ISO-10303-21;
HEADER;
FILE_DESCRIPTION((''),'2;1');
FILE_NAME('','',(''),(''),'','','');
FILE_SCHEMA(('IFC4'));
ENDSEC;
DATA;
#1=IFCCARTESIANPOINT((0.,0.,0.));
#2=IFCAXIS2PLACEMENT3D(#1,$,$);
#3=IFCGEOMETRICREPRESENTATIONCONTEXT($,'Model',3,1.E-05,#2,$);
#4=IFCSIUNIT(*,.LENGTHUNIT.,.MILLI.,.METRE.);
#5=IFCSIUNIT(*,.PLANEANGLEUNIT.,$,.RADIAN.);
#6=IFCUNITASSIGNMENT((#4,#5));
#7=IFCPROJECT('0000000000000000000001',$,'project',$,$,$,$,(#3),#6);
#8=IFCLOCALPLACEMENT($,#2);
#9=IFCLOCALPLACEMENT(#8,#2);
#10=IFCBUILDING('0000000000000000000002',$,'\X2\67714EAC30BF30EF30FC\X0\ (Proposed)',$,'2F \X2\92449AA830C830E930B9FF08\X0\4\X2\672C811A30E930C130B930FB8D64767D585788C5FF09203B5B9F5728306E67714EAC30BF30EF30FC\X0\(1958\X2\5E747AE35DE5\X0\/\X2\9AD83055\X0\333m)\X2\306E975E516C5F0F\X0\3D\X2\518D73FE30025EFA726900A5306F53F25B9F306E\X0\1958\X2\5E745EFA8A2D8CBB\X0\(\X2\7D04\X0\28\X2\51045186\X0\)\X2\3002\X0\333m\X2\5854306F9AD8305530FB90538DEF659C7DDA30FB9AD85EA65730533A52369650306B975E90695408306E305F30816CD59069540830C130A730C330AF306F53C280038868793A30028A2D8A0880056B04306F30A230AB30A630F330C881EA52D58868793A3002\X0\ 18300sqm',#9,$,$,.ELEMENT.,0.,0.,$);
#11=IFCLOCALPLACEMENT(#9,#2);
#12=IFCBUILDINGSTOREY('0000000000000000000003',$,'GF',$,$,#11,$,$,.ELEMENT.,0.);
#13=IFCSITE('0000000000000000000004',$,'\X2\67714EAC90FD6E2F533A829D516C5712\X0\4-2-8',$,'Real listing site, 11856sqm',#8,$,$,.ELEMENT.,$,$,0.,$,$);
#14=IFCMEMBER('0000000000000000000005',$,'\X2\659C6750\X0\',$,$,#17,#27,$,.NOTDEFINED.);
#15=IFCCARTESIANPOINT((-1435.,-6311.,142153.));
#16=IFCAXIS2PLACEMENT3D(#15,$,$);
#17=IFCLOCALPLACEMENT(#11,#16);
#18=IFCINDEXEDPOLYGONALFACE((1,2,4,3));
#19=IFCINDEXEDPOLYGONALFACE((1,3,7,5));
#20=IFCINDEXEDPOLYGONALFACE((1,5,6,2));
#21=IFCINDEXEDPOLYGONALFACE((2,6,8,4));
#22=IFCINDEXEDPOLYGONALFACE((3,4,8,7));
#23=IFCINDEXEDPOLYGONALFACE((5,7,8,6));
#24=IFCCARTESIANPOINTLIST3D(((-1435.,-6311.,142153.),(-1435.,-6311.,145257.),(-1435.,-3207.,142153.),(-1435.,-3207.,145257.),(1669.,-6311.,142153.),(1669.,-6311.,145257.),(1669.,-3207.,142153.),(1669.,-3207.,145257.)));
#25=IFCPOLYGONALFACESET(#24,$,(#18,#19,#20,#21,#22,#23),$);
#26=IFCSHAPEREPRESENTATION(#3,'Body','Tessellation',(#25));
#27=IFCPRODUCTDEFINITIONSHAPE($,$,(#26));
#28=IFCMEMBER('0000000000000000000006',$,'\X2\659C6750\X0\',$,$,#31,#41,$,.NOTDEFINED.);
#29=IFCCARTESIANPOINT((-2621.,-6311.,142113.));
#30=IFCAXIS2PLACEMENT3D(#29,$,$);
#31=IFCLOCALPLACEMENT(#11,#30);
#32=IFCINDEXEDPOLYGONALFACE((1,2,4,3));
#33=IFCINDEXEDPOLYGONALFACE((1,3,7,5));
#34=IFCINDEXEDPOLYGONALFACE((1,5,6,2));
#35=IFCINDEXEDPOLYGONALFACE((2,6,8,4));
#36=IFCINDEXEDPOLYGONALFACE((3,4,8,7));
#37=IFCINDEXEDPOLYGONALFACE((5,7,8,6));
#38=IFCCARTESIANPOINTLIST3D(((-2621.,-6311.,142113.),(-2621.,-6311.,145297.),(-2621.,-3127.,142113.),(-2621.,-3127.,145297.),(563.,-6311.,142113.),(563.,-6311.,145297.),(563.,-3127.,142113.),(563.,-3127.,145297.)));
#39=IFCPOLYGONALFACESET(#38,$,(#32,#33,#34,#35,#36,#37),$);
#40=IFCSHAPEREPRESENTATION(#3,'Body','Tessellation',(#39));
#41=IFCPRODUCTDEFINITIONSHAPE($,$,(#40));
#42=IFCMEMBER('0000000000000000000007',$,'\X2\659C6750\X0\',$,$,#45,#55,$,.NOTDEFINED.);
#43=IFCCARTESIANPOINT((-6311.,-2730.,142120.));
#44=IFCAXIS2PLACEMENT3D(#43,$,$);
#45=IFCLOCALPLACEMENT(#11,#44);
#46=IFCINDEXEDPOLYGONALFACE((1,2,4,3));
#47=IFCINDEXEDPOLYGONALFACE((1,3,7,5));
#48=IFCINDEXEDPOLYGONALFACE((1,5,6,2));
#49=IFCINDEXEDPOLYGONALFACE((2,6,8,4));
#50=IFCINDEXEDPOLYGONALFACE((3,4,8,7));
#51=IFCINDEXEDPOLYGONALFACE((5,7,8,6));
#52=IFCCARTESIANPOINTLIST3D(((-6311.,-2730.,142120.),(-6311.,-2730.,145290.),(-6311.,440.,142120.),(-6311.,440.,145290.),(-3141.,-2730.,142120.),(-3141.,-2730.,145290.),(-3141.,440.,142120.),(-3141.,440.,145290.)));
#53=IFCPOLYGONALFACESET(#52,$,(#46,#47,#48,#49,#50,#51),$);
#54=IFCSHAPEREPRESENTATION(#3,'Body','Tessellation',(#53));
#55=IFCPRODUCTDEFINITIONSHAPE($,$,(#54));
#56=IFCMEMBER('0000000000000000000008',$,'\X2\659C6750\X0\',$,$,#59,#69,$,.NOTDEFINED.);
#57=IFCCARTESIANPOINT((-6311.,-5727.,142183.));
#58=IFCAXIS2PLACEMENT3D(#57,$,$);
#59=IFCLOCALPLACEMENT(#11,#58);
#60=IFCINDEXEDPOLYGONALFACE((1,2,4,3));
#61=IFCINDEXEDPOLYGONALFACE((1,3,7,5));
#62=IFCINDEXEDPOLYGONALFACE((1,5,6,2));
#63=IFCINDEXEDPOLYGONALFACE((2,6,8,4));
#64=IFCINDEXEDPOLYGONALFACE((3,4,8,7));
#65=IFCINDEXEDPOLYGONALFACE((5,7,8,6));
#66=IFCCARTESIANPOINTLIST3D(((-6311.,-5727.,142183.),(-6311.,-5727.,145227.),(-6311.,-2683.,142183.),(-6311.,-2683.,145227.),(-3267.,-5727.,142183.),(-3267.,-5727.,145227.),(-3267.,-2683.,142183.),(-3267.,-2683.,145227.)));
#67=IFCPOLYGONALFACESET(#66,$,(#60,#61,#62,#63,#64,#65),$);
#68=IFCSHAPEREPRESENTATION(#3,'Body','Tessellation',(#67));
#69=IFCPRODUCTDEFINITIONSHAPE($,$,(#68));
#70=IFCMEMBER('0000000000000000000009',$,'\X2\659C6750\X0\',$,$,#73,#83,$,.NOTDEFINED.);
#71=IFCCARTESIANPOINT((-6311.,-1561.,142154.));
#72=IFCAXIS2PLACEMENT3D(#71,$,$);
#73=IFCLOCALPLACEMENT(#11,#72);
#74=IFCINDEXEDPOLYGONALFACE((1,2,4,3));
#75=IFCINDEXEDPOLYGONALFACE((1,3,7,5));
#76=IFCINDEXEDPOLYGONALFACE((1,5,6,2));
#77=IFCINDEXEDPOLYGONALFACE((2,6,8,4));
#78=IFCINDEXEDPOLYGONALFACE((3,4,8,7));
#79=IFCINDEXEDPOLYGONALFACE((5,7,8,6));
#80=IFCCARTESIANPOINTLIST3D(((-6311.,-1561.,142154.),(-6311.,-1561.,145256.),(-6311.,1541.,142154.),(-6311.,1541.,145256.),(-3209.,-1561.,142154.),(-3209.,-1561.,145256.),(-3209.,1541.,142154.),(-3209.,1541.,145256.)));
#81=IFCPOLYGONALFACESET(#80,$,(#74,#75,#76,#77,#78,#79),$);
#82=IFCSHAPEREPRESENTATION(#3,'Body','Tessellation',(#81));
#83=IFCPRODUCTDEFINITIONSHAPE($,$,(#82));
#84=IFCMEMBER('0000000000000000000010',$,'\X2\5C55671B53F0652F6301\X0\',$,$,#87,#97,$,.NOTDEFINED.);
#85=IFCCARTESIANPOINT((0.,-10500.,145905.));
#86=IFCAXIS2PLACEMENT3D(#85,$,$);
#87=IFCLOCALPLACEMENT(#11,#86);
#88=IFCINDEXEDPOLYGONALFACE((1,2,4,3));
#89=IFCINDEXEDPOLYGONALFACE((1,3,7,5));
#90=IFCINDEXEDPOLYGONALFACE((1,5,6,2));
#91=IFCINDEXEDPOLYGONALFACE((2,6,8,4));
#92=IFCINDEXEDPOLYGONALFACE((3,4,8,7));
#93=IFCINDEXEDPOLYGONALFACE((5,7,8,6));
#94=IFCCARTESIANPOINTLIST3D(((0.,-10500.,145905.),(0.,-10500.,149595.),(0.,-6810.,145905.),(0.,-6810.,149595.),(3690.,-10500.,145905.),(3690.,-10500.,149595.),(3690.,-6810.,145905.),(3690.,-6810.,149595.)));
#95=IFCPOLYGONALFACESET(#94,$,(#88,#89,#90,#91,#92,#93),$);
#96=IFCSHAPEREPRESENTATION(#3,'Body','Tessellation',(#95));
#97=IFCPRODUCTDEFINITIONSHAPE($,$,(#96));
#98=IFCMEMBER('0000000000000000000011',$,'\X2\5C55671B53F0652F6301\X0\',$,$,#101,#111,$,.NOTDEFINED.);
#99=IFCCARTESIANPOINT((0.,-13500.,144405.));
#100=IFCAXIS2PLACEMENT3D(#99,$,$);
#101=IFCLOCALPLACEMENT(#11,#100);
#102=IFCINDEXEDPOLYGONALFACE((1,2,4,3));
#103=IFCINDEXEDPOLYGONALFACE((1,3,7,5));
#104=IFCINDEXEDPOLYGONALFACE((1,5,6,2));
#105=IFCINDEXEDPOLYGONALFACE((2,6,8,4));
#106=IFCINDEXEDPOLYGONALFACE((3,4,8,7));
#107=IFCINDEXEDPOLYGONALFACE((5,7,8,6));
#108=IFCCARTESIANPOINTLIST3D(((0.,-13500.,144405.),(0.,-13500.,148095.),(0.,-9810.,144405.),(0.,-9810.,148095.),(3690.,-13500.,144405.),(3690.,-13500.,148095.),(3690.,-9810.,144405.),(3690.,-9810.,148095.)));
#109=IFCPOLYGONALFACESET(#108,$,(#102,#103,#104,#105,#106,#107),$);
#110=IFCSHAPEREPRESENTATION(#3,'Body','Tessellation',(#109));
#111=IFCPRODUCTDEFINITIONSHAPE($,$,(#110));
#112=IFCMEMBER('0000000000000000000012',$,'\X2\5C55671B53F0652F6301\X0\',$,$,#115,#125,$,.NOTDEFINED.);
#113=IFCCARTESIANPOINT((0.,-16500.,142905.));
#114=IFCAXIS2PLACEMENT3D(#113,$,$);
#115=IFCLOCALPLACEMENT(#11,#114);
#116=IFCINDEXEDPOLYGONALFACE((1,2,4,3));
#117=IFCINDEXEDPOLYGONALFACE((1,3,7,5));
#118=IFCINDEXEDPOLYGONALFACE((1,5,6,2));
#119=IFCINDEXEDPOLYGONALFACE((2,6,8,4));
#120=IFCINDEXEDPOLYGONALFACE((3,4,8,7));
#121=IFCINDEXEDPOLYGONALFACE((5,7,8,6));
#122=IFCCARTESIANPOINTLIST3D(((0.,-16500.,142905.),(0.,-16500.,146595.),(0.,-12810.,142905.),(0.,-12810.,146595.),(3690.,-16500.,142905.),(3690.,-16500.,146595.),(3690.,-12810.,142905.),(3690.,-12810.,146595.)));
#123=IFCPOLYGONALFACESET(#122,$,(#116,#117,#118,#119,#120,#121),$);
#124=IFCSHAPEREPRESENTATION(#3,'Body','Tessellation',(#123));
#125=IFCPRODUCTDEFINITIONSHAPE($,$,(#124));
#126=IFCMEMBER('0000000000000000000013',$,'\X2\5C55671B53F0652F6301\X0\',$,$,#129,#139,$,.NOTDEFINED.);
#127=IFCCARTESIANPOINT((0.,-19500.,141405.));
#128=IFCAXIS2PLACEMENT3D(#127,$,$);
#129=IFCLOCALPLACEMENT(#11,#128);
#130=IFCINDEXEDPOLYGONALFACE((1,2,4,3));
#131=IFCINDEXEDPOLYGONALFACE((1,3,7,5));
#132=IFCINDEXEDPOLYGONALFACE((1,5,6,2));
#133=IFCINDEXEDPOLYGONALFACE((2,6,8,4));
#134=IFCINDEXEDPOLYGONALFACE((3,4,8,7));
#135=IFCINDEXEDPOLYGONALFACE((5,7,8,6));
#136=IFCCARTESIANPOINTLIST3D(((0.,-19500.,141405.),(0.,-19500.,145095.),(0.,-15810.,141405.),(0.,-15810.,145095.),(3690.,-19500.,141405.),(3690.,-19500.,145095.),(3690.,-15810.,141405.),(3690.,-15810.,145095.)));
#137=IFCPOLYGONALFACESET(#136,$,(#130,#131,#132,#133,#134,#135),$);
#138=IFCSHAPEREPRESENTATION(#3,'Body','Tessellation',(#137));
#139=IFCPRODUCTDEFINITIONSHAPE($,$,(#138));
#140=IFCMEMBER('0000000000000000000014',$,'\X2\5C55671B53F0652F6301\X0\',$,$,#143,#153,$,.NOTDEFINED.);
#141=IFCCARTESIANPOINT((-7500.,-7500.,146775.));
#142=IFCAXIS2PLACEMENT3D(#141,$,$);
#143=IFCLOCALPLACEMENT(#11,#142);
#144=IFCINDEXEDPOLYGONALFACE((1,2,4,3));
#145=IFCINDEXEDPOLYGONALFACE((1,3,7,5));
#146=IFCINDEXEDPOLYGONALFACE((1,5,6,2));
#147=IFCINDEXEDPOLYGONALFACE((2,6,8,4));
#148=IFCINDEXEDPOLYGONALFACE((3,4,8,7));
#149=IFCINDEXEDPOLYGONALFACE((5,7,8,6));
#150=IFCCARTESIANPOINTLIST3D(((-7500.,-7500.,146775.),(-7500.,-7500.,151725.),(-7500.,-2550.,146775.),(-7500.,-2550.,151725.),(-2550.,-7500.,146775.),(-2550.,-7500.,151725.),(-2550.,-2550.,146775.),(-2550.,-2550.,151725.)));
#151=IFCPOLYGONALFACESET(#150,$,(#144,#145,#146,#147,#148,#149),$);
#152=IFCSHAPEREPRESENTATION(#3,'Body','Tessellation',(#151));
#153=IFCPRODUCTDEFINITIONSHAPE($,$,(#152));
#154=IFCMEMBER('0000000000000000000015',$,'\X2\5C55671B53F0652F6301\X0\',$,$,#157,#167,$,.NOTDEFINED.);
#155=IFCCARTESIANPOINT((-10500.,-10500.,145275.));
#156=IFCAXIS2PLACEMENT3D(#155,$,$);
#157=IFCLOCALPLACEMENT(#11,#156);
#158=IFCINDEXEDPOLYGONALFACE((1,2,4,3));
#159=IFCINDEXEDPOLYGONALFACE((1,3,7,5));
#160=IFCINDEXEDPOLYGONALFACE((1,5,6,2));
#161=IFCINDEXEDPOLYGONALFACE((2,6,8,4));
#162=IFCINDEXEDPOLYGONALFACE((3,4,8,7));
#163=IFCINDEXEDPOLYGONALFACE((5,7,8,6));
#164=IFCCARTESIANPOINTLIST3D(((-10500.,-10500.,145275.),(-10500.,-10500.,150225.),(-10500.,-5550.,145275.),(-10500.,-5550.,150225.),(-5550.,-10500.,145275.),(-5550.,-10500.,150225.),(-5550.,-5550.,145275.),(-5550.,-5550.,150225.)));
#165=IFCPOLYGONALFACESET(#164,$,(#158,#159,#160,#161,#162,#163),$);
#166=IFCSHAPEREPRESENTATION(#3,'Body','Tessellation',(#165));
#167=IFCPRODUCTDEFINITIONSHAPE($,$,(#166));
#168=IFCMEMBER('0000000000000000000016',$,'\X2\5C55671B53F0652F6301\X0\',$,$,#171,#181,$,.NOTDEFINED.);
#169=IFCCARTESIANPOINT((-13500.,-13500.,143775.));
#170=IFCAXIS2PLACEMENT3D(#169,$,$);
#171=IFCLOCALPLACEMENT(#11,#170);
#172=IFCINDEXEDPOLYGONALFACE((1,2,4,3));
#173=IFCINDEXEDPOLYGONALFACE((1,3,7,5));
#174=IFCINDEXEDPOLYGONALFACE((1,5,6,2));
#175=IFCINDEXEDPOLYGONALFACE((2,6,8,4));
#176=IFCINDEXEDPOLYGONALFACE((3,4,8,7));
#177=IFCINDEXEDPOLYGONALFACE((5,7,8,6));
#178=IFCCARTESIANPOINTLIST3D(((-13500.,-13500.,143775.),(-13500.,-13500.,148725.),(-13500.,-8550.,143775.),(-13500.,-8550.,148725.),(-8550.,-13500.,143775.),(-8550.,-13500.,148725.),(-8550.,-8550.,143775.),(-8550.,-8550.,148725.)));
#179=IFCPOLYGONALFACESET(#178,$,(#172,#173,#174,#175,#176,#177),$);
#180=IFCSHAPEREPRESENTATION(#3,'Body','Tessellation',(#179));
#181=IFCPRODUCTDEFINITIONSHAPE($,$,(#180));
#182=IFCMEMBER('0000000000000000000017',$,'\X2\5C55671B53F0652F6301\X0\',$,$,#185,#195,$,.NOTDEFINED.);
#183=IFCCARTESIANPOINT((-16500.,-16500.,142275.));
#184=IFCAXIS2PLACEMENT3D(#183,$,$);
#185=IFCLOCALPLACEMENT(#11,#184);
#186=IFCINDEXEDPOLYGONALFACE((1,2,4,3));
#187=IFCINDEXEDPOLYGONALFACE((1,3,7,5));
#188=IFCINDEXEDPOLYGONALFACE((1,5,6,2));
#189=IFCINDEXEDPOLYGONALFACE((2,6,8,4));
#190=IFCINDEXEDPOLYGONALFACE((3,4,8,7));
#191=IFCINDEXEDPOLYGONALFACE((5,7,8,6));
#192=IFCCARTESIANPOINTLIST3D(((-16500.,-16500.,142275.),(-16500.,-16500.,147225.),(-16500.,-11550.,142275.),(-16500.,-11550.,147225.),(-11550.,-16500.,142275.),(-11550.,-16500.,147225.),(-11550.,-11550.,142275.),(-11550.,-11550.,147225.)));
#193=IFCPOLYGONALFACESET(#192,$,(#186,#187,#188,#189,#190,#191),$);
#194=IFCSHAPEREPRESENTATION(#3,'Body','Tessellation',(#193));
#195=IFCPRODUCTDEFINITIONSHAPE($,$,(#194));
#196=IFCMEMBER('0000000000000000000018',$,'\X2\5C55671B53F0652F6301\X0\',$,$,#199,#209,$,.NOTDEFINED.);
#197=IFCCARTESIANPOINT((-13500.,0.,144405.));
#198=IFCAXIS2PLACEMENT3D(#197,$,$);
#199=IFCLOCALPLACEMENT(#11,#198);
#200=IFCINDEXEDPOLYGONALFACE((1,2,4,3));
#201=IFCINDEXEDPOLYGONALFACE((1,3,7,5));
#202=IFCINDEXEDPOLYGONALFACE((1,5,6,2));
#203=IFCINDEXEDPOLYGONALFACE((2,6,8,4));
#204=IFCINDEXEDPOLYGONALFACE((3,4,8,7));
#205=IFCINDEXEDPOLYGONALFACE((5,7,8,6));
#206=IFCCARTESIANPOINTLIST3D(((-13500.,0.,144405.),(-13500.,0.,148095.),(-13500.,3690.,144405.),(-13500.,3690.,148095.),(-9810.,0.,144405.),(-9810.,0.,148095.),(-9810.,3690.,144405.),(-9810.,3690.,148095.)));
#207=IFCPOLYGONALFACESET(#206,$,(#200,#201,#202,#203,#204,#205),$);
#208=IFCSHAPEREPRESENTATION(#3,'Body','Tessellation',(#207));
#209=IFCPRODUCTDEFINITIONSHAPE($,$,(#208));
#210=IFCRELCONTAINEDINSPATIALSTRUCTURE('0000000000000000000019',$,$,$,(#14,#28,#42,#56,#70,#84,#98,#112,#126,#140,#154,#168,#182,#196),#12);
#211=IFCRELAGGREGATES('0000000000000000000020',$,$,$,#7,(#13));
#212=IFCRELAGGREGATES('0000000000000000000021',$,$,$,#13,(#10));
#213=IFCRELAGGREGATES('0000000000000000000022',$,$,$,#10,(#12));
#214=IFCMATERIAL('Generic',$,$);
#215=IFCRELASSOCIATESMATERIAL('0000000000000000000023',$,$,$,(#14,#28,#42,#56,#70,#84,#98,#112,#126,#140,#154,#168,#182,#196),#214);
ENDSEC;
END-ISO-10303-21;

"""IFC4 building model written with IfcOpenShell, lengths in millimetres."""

from ifc_helpers import new_model, si_unit, frame, frame_2d, origin, place, context, project, spatial, rectangle, extrude, material, element, save


model = new_model("IFC4")

# Units and contexts
model_context = context("Model", 3, precision=1e-05, world=origin())
ifc_project = project(units=[si_unit("LENGTHUNIT", "METRE", prefix="MILLI"), si_unit("PLANEANGLEUNIT", "RADIAN")], contexts=[model_context])

# Site, building, storey
site_placement = place(None, origin())
site = spatial("IfcSite", under=ifc_project, at=site_placement, Name="東京都港区芝公園4-2-8", ObjectType="Real listing site, 11856sqm", CompositionType="ELEMENT", RefElevation=0.0)
building_placement = place(site_placement, origin())
building = spatial("IfcBuilding", under=site, at=building_placement, Name="東京タワー (Proposed)", ObjectType="2F 鉄骨トラス（4本脚ラチス・赤白塗装）※実在の東京タワー(1958年竣工/高さ333m)の非公式3D再現。建物¥は史実の1958年建設費(約28億円)。333m塔は高さ・道路斜線・高度地区制限に非適合のため法適合チェックは参考表示。設計者欄はアカウント自動表示。 18300sqm", CompositionType="ELEMENT", ElevationOfRefHeight=0.0, ElevationOfTerrain=0.0)
storey_placement = place(building_placement, origin())
storey = spatial("IfcBuildingStorey", under=building, at=storey_placement, Name="GF", CompositionType="ELEMENT", Elevation=0.0)

# Shared definitions
ifc_material = material(Name="Generic")

# Members
member_1_placement = place(storey_placement, frame((-1435.0, -6311.0, 142153.0)))
element("IfcMember", 1, at=member_1_placement, inside=storey, material=ifc_material, Name="斜材", PredefinedType="NOTDEFINED", context=model_context, shape_type="SweptSolid", body=[
    extrude(rectangle(XDim=3104.0, YDim=3104.0, at=frame_2d((1552.0, 1552.0))), frame((-1435.0, -6311.0, 142153.0)), (0.0, 0.0, 1.0), 3104.0),
])
member_2_placement = place(storey_placement, frame((-2621.0, -6311.0, 142113.0)))
element("IfcMember", 2, at=member_2_placement, inside=storey, material=ifc_material, Name="斜材", PredefinedType="NOTDEFINED", context=model_context, shape_type="SweptSolid", body=[
    extrude(rectangle(XDim=3184.0, YDim=3184.0, at=frame_2d((1592.0, 1592.0))), frame((-2621.0, -6311.0, 142113.0)), (0.0, 0.0, 1.0), 3184.0),
])
member_3_placement = place(storey_placement, frame((-6311.0, -2730.0, 142120.0)))
element("IfcMember", 3, at=member_3_placement, inside=storey, material=ifc_material, Name="斜材", PredefinedType="NOTDEFINED", context=model_context, shape_type="SweptSolid", body=[
    extrude(rectangle(XDim=3170.0, YDim=3170.0, at=frame_2d((1585.0, 1585.0))), frame((-6311.0, -2730.0, 142120.0)), (0.0, 0.0, 1.0), 3170.0),
])
member_4_placement = place(storey_placement, frame((-6311.0, -5727.0, 142183.0)))
element("IfcMember", 4, at=member_4_placement, inside=storey, material=ifc_material, Name="斜材", PredefinedType="NOTDEFINED", context=model_context, shape_type="SweptSolid", body=[
    extrude(rectangle(XDim=3044.0, YDim=3044.0, at=frame_2d((1522.0, 1522.0))), frame((-6311.0, -5727.0, 142183.0)), (0.0, 0.0, 1.0), 3044.0),
])
member_5_placement = place(storey_placement, frame((-6311.0, -1561.0, 142154.0)))
element("IfcMember", 5, at=member_5_placement, inside=storey, material=ifc_material, Name="斜材", PredefinedType="NOTDEFINED", context=model_context, shape_type="SweptSolid", body=[
    extrude(rectangle(XDim=3102.0, YDim=3102.0, at=frame_2d((1551.0, 1551.0))), frame((-6311.0, -1561.0, 142154.0)), (0.0, 0.0, 1.0), 3102.0),
])
member_6_placement = place(storey_placement, frame((0.0, -10500.0, 145905.0)))
element("IfcMember", 6, at=member_6_placement, inside=storey, material=ifc_material, Name="展望台支持", PredefinedType="NOTDEFINED", context=model_context, shape_type="SweptSolid", body=[
    extrude(rectangle(XDim=3690.0, YDim=3690.0, at=frame_2d((1845.0, 1845.0))), frame((0.0, -10500.0, 145905.0)), (0.0, 0.0, 1.0), 3690.0),
])
member_7_placement = place(storey_placement, frame((0.0, -13500.0, 144405.0)))
element("IfcMember", 7, at=member_7_placement, inside=storey, material=ifc_material, Name="展望台支持", PredefinedType="NOTDEFINED", context=model_context, shape_type="SweptSolid", body=[
    extrude(rectangle(XDim=3690.0, YDim=3690.0, at=frame_2d((1845.0, 1845.0))), frame((0.0, -13500.0, 144405.0)), (0.0, 0.0, 1.0), 3690.0),
])
member_8_placement = place(storey_placement, frame((0.0, -16500.0, 142905.0)))
element("IfcMember", 8, at=member_8_placement, inside=storey, material=ifc_material, Name="展望台支持", PredefinedType="NOTDEFINED", context=model_context, shape_type="SweptSolid", body=[
    extrude(rectangle(XDim=3690.0, YDim=3690.0, at=frame_2d((1845.0, 1845.0))), frame((0.0, -16500.0, 142905.0)), (0.0, 0.0, 1.0), 3690.0),
])
member_9_placement = place(storey_placement, frame((0.0, -19500.0, 141405.0)))
element("IfcMember", 9, at=member_9_placement, inside=storey, material=ifc_material, Name="展望台支持", PredefinedType="NOTDEFINED", context=model_context, shape_type="SweptSolid", body=[
    extrude(rectangle(XDim=3690.0, YDim=3690.0, at=frame_2d((1845.0, 1845.0))), frame((0.0, -19500.0, 141405.0)), (0.0, 0.0, 1.0), 3690.0),
])
member_10_placement = place(storey_placement, frame((-7500.0, -7500.0, 146775.0)))
element("IfcMember", 10, at=member_10_placement, inside=storey, material=ifc_material, Name="展望台支持", PredefinedType="NOTDEFINED", context=model_context, shape_type="SweptSolid", body=[
    extrude(rectangle(XDim=4950.0, YDim=4950.0, at=frame_2d((2475.0, 2475.0))), frame((-7500.0, -7500.0, 146775.0)), (0.0, 0.0, 1.0), 4950.0),
])
member_11_placement = place(storey_placement, frame((-10500.0, -10500.0, 145275.0)))
element("IfcMember", 11, at=member_11_placement, inside=storey, material=ifc_material, Name="展望台支持", PredefinedType="NOTDEFINED", context=model_context, shape_type="SweptSolid", body=[
    extrude(rectangle(XDim=4950.0, YDim=4950.0, at=frame_2d((2475.0, 2475.0))), frame((-10500.0, -10500.0, 145275.0)), (0.0, 0.0, 1.0), 4950.0),
])
member_12_placement = place(storey_placement, frame((-13500.0, -13500.0, 143775.0)))
element("IfcMember", 12, at=member_12_placement, inside=storey, material=ifc_material, Name="展望台支持", PredefinedType="NOTDEFINED", context=model_context, shape_type="SweptSolid", body=[
    extrude(rectangle(XDim=4950.0, YDim=4950.0, at=frame_2d((2475.0, 2475.0))), frame((-13500.0, -13500.0, 143775.0)), (0.0, 0.0, 1.0), 4950.0),
])
member_13_placement = place(storey_placement, frame((-16500.0, -16500.0, 142275.0)))
element("IfcMember", 13, at=member_13_placement, inside=storey, material=ifc_material, Name="展望台支持", PredefinedType="NOTDEFINED", context=model_context, shape_type="SweptSolid", body=[
    extrude(rectangle(XDim=4950.0, YDim=4950.0, at=frame_2d((2475.0, 2475.0))), frame((-16500.0, -16500.0, 142275.0)), (0.0, 0.0, 1.0), 4950.0),
])
member_14_placement = place(storey_placement, frame((-13500.0, 0.0, 144405.0)))
element("IfcMember", 14, at=member_14_placement, inside=storey, material=ifc_material, Name="展望台支持", PredefinedType="NOTDEFINED", context=model_context, shape_type="SweptSolid", body=[
    extrude(rectangle(XDim=3690.0, YDim=3690.0, at=frame_2d((1845.0, 1845.0))), frame((-13500.0, 0.0, 144405.0)), (0.0, 0.0, 1.0), 3690.0),
])

save(model, "model.ifc")
